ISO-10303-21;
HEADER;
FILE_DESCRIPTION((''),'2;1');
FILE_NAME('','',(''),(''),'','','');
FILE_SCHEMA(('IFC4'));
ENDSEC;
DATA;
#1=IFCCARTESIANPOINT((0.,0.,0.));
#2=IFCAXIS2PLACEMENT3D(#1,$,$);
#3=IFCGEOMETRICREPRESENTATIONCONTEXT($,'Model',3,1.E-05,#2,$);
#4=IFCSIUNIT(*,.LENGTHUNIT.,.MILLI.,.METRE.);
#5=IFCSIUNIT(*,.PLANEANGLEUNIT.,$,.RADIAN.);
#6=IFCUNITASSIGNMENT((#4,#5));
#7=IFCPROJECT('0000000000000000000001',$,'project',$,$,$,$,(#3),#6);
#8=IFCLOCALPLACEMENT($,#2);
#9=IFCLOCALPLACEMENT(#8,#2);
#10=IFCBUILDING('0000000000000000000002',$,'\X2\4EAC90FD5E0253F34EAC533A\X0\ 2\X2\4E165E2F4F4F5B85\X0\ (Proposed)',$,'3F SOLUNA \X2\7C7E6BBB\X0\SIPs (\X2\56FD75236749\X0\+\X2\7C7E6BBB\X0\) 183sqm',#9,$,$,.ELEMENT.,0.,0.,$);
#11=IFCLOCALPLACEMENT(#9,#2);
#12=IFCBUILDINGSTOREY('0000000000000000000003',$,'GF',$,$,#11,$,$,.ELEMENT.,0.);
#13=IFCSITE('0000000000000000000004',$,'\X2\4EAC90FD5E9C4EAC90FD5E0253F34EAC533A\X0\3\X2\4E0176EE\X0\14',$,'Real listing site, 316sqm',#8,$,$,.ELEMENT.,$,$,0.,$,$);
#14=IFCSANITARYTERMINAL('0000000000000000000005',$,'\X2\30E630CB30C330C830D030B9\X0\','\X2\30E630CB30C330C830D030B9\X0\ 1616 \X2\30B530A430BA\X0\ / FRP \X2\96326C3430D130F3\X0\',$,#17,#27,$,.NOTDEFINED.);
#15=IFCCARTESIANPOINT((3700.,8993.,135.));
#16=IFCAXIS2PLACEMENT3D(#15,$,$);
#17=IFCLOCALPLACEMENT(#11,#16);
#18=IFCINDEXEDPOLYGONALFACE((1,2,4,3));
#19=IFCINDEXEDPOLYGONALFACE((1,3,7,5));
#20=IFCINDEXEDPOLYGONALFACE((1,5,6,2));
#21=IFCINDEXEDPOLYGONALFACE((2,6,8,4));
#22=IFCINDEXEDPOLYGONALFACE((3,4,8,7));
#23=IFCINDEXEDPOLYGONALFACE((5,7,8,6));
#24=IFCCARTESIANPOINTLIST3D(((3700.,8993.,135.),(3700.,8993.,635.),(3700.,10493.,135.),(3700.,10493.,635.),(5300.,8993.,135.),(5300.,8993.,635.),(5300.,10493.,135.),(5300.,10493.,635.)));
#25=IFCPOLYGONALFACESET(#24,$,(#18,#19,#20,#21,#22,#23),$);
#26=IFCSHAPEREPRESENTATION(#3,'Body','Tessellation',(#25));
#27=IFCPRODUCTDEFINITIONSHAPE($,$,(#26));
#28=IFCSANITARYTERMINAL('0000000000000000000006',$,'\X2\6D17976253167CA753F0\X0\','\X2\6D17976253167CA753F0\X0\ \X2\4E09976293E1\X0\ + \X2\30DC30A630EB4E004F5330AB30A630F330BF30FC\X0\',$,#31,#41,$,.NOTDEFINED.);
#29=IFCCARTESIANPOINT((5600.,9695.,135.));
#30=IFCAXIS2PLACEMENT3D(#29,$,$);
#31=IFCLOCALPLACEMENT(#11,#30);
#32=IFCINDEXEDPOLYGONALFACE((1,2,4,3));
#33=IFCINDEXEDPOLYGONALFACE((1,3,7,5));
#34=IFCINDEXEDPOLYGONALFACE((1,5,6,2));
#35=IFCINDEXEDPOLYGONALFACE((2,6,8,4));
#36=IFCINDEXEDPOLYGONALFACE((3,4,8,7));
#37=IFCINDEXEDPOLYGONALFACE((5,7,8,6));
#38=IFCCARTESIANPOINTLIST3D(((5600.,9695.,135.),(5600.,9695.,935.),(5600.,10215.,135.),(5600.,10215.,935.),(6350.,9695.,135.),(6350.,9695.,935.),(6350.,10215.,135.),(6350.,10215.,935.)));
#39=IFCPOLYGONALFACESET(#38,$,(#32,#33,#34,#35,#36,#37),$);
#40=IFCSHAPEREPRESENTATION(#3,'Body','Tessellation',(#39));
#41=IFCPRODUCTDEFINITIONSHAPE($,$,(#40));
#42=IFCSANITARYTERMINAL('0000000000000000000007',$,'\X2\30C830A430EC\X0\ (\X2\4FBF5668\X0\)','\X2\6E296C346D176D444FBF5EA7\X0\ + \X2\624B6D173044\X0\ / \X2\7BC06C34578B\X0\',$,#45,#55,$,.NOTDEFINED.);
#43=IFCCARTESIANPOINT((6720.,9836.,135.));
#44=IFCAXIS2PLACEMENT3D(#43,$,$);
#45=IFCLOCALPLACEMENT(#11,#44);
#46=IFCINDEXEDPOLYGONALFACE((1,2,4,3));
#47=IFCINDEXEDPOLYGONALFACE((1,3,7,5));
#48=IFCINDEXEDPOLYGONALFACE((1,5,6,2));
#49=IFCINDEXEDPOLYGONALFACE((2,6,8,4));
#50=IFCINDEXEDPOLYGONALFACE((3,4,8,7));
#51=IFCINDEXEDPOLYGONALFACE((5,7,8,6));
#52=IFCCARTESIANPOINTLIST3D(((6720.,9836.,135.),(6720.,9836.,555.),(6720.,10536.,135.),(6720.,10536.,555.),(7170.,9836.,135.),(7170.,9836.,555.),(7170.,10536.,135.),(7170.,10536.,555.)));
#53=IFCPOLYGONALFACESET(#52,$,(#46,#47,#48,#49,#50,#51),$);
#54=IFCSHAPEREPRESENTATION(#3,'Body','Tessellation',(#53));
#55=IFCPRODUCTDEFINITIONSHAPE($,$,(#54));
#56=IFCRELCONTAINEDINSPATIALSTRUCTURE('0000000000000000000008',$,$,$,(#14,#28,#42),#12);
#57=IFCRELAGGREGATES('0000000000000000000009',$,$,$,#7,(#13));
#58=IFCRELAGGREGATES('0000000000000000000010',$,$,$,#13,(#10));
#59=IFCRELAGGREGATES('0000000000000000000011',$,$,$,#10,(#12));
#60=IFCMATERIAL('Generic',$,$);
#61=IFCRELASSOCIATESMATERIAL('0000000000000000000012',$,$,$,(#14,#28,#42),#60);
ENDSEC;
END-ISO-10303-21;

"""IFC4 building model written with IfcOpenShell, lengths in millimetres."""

from ifc_helpers import new_model, si_unit, frame, frame_2d, origin, place, context, project, spatial, rectangle, extrude, material, element, save


model = new_model("IFC4")

# Units and contexts
model_context = context("Model", 3, precision=1e-05, world=origin())
ifc_project = project(units=[si_unit("LENGTHUNIT", "METRE", prefix="MILLI"), si_unit("PLANEANGLEUNIT", "RADIAN")], contexts=[model_context])

# Site, building, storey
site_placement = place(None, origin())
site = spatial("IfcSite", under=ifc_project, at=site_placement, Name="京都府京都市右京区3丁目14", ObjectType="Real listing site, 316sqm", CompositionType="ELEMENT", RefElevation=0.0)
building_placement = place(site_placement, origin())
building = spatial("IfcBuilding", under=site, at=building_placement, Name="京都市右京区 2世帯住宅 (Proposed)", ObjectType="3F SOLUNA 籾殻SIPs (国産杉+籾殻) 183sqm", CompositionType="ELEMENT", ElevationOfRefHeight=0.0, ElevationOfTerrain=0.0)
storey_placement = place(building_placement, origin())
storey = spatial("IfcBuildingStorey", under=building, at=storey_placement, Name="GF", CompositionType="ELEMENT", Elevation=0.0)

# Shared definitions
ifc_material_1 = material(Name="Generic")

# Sanitary terminals
sanitary_terminal_1_placement = place(storey_placement, frame((3700.0, 8993.0, 135.0)))
element("IfcSanitaryTerminal", 1, at=sanitary_terminal_1_placement, inside=storey, material=ifc_material_1, Name="ユニットバス", Description="ユニットバス 1616 サイズ / FRP 防水パン", PredefinedType="NOTDEFINED", context=model_context, shape_type="SweptSolid", body=[
    extrude(rectangle(XDim=1600.0, YDim=1500.0, at=frame_2d((800.0, 750.0))), frame((3700.0, 8993.0, 135.0)), (0.0, 0.0, 1.0), 500.0),
])
sanitary_terminal_2_placement = place(storey_placement, frame((5600.0, 9695.0, 135.0)))
element("IfcSanitaryTerminal", 2, at=sanitary_terminal_2_placement, inside=storey, material=ifc_material_1, Name="洗面化粧台", Description="洗面化粧台 三面鏡 + ボウル一体カウンター", PredefinedType="NOTDEFINED", context=model_context, shape_type="SweptSolid", body=[
    extrude(rectangle(XDim=750.0, YDim=520.0, at=frame_2d((375.0, 260.0))), frame((5600.0, 9695.0, 135.0)), (0.0, 0.0, 1.0), 800.0),
])
sanitary_terminal_3_placement = place(storey_placement, frame((6720.0, 9836.0, 135.0)))
element("IfcSanitaryTerminal", 3, at=sanitary_terminal_3_placement, inside=storey, material=ifc_material_1, Name="トイレ (便器)", Description="温水洗浄便座 + 手洗い / 節水型", PredefinedType="NOTDEFINED", context=model_context, shape_type="SweptSolid", body=[
    extrude(rectangle(XDim=450.0, YDim=700.0, at=frame_2d((225.0, 350.0))), frame((6720.0, 9836.0, 135.0)), (0.0, 0.0, 1.0), 420.0),
])

save(model, "model.ifc")
